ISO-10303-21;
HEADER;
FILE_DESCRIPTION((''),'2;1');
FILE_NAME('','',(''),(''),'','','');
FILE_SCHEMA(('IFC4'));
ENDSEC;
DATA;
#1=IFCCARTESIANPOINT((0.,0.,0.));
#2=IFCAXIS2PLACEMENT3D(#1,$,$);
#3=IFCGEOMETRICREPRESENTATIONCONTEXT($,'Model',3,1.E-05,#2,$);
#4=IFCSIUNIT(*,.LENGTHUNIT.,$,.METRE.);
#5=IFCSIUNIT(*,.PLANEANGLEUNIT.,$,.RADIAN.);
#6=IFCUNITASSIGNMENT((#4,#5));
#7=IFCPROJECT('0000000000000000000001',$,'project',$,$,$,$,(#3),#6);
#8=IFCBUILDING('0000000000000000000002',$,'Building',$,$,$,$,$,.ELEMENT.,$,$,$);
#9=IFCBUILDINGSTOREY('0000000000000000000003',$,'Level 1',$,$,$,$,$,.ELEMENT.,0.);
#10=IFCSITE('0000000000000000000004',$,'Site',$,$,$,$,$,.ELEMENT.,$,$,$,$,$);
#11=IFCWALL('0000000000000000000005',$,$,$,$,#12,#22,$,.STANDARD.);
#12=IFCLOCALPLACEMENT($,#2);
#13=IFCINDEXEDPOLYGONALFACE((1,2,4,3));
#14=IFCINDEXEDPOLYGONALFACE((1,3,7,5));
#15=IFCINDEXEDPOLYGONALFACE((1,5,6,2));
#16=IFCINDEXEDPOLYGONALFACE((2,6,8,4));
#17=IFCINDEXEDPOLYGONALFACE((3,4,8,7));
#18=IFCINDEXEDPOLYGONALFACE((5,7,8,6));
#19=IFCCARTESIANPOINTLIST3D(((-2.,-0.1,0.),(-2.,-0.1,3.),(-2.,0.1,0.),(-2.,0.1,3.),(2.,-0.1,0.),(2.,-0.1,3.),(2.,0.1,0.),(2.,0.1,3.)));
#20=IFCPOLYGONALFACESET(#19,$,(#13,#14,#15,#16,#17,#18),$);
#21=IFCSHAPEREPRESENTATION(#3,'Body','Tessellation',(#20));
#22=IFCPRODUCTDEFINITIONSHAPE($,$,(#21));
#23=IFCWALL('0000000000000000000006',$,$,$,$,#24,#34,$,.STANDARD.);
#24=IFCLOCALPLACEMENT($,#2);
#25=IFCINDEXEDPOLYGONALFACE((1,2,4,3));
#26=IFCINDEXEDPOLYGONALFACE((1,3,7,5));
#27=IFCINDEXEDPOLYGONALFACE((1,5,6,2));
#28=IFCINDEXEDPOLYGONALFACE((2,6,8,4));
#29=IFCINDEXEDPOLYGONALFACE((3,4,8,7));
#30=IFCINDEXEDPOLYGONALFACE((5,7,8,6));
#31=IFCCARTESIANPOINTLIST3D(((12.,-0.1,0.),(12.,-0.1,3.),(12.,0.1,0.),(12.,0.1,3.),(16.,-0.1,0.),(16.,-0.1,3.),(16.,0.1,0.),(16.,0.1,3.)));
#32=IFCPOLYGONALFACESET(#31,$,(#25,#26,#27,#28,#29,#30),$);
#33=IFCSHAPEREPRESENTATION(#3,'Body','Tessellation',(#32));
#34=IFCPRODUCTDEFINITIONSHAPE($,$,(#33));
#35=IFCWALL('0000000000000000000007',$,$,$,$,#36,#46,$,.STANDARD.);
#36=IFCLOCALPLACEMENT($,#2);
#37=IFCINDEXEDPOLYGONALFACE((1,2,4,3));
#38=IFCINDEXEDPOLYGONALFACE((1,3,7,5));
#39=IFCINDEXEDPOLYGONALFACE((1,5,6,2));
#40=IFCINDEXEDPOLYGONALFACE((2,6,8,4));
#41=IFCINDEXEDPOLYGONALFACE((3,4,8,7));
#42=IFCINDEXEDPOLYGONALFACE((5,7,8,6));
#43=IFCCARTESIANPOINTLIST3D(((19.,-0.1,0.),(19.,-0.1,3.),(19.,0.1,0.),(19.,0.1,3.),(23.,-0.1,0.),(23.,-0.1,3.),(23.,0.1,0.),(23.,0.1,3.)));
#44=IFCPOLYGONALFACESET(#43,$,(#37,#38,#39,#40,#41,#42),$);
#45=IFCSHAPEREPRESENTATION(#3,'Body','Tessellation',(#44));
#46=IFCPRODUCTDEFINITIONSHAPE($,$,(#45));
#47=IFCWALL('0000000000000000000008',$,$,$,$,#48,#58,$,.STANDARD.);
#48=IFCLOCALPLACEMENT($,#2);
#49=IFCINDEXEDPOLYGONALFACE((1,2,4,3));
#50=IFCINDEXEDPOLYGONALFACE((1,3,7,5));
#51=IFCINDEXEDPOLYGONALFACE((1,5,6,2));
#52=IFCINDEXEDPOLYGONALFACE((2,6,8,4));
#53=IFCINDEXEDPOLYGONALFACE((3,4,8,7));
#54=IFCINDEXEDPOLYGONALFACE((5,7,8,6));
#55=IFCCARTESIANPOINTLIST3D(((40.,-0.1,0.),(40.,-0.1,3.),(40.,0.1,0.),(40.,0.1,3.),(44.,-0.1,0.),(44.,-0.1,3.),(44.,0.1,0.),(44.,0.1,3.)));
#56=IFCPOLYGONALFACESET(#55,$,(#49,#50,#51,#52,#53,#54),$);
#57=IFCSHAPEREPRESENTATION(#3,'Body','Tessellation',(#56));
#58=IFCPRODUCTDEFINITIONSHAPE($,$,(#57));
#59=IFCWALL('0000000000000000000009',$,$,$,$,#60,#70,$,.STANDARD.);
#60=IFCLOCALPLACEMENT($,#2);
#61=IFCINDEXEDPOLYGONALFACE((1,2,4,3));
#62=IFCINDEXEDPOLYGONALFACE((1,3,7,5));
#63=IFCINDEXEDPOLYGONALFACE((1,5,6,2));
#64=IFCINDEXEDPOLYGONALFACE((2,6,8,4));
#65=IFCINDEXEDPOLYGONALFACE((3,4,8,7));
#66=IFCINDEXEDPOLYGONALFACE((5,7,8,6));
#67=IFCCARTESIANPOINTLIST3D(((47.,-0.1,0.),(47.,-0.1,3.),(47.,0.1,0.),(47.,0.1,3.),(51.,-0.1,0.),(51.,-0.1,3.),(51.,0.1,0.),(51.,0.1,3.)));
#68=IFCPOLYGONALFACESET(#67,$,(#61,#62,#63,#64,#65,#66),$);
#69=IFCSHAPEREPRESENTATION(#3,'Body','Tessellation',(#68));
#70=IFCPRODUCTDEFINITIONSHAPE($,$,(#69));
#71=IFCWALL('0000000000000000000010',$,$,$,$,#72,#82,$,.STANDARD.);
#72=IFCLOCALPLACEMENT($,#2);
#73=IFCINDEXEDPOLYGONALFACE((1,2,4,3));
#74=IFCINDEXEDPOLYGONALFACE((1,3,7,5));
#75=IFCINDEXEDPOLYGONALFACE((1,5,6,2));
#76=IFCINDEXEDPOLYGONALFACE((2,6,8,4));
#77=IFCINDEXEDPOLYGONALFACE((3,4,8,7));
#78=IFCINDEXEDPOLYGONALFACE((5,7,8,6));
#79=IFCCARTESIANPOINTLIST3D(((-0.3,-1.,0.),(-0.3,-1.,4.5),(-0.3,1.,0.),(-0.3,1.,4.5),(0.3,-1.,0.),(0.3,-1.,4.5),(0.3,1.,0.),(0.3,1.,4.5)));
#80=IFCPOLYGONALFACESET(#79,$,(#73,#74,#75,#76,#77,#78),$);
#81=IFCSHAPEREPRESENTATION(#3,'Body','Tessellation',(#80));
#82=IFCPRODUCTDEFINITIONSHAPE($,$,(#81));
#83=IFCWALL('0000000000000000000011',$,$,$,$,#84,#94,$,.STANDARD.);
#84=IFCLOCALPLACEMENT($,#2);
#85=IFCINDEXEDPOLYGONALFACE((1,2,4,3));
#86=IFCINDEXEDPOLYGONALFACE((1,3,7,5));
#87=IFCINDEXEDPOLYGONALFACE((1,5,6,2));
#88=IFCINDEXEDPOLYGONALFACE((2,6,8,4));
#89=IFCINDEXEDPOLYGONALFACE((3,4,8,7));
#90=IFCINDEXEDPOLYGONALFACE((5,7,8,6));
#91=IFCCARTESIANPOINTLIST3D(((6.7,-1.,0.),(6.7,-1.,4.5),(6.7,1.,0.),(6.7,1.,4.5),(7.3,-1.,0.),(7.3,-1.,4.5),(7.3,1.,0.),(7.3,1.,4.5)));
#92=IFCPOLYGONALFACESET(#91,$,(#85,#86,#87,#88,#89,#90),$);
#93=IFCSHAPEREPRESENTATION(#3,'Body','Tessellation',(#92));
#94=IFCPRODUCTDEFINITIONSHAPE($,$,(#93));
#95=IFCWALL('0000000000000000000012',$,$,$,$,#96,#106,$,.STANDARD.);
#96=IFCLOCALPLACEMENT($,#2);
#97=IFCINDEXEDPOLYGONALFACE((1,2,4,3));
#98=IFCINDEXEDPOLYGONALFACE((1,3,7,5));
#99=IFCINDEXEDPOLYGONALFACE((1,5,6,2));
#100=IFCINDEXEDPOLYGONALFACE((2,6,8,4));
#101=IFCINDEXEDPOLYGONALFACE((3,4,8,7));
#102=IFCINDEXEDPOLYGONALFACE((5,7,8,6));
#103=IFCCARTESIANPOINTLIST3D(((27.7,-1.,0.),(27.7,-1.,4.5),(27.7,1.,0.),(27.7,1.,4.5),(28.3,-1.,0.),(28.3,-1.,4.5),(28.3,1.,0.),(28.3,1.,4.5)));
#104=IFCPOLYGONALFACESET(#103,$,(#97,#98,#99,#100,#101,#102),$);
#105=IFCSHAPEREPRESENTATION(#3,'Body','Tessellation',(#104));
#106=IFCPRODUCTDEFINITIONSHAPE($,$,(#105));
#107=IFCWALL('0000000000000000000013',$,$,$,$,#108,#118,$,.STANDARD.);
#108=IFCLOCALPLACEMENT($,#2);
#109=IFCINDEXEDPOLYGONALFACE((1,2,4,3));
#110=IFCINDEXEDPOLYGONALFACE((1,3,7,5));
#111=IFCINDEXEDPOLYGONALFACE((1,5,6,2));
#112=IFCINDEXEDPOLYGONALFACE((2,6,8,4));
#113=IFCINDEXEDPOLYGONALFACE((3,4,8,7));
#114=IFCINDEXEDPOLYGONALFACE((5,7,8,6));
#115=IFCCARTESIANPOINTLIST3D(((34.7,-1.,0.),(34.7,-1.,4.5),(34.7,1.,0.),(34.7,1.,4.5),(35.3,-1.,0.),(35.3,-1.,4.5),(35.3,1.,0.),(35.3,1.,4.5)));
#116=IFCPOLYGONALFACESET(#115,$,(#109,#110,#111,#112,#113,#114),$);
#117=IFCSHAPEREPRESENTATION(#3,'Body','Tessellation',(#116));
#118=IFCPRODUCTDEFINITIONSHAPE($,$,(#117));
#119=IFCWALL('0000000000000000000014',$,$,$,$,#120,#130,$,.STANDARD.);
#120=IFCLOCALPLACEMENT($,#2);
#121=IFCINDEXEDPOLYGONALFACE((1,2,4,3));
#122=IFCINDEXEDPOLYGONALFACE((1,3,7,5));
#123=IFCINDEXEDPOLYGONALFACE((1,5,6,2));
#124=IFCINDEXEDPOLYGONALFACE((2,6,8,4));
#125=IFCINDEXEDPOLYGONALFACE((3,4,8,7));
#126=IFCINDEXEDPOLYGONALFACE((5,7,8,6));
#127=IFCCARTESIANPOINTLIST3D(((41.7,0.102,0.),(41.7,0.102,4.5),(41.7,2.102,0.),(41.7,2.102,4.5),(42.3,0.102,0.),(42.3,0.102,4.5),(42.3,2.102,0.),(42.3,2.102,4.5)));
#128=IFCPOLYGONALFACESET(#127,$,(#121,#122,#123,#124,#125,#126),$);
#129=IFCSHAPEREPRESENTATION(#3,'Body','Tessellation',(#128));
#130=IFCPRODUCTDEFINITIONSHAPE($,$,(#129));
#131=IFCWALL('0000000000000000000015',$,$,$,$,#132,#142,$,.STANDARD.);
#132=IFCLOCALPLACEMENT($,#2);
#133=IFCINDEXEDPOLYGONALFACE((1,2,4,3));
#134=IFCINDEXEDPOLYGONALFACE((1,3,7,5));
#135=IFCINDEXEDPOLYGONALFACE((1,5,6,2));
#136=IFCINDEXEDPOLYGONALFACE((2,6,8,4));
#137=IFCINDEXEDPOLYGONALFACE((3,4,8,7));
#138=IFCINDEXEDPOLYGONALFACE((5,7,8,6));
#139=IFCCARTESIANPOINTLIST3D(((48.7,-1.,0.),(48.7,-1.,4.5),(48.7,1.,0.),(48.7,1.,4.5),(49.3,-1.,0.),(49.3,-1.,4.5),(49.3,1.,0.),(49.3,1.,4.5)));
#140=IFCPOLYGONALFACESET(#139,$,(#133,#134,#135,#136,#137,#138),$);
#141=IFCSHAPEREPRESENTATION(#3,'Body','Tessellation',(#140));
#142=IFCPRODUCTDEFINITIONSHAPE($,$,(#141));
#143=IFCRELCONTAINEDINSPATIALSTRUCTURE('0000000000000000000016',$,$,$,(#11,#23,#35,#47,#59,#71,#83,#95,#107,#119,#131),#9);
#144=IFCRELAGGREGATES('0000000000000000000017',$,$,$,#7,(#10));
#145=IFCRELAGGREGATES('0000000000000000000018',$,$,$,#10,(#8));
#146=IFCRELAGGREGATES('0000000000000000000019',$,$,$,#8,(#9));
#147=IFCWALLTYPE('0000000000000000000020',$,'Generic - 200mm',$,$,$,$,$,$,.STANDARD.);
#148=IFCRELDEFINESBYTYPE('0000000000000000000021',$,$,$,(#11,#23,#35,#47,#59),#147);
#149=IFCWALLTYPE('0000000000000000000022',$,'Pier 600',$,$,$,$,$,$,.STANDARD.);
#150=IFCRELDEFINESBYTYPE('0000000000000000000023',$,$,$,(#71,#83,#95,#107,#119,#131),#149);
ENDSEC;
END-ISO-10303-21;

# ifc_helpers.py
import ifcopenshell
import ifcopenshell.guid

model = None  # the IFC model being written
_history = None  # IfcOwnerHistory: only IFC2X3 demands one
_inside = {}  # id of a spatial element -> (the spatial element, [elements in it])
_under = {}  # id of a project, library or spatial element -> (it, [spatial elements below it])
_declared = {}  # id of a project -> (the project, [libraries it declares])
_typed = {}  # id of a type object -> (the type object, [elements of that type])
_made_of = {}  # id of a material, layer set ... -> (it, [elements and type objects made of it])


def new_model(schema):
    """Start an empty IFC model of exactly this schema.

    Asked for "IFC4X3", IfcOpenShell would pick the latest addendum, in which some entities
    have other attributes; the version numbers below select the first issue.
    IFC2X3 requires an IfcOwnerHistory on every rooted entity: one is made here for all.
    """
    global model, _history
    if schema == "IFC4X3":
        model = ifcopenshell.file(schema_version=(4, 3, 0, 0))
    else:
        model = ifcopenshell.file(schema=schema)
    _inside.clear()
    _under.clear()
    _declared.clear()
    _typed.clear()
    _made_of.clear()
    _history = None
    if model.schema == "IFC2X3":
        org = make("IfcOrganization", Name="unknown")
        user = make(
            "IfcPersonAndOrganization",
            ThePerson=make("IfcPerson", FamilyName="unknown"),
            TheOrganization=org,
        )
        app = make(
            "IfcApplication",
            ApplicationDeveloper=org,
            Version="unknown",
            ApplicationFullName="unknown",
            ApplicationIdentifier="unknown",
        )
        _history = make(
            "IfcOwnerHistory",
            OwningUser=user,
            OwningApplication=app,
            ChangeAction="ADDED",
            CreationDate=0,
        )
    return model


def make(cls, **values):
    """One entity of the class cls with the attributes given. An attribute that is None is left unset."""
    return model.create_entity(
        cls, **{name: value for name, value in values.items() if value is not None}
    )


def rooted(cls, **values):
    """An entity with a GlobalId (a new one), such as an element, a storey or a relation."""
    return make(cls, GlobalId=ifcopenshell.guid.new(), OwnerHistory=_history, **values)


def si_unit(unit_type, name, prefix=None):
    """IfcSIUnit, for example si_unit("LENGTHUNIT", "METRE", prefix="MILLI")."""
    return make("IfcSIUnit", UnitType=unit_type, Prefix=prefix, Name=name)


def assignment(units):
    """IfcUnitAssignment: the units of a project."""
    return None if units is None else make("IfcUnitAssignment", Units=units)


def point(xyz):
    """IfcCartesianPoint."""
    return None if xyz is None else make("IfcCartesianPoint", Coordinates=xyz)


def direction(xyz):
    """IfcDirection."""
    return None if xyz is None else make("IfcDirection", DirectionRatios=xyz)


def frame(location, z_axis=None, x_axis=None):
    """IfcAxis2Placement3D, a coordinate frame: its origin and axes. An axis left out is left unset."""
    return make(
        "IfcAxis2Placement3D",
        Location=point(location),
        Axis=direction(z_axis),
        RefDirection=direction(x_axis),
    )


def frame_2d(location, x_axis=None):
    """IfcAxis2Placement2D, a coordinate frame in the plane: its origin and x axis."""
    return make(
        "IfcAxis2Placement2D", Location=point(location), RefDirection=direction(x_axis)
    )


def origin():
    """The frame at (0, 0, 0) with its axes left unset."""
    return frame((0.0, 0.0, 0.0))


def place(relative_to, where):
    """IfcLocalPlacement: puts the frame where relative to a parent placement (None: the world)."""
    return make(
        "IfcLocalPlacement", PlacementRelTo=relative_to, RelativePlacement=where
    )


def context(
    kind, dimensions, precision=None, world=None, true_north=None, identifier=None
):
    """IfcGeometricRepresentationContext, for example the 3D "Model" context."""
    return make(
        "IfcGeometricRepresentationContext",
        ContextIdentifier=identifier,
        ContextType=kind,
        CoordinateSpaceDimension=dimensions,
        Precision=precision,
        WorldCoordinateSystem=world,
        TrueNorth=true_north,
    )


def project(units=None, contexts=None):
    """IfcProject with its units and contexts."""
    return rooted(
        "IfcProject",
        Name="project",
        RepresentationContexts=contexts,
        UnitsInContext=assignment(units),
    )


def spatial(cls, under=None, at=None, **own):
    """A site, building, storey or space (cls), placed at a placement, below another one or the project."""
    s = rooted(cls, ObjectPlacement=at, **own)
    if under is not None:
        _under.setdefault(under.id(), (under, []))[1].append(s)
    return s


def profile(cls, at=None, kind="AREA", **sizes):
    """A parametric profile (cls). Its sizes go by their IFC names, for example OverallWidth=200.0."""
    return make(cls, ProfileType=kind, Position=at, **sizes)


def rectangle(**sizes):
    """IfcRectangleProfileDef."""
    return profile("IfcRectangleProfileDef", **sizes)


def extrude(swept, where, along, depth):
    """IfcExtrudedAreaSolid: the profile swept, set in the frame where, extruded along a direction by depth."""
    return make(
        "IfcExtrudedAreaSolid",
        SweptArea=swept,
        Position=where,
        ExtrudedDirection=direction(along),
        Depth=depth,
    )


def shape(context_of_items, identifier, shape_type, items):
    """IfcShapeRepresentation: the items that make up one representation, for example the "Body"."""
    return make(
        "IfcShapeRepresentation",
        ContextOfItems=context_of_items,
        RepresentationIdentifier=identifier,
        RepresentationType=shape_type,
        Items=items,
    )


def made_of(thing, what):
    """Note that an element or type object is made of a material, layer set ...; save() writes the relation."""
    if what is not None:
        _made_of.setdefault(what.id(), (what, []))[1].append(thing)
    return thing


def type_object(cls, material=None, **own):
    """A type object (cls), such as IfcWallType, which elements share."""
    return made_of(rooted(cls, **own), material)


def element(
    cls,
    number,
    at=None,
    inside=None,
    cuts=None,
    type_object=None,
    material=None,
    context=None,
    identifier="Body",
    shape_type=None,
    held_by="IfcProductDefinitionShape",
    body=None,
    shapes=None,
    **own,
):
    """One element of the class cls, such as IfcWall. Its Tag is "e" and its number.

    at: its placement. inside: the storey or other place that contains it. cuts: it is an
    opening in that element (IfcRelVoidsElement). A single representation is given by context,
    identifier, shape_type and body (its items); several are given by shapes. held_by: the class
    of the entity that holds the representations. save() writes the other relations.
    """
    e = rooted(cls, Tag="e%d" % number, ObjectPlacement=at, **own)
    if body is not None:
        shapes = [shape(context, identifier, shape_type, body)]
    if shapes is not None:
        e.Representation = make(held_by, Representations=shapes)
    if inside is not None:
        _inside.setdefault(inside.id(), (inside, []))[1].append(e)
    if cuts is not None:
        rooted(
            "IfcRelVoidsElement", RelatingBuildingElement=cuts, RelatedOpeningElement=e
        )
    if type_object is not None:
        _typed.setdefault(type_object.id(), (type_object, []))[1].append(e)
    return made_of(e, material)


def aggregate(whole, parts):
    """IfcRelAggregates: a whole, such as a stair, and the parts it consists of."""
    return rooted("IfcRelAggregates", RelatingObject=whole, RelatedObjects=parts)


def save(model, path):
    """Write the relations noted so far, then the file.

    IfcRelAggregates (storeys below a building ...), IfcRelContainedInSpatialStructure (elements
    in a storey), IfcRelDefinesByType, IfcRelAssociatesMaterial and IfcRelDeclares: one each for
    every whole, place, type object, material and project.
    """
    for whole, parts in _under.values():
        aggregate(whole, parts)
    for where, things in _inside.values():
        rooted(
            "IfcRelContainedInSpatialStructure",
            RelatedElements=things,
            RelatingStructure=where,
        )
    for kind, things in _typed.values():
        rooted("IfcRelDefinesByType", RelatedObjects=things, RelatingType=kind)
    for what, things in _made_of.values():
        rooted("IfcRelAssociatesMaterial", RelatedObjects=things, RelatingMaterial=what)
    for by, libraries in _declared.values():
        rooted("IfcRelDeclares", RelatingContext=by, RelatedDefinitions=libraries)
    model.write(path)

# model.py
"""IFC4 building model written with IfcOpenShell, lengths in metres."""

from ifc_helpers import new_model, si_unit, frame, frame_2d, origin, place, context, project, spatial, rectangle, extrude, type_object, element, save


model = new_model("IFC4")

# Units and contexts
model_context = context("Model", 3, precision=1e-05, world=origin())
ifc_project = project(units=[si_unit("LENGTHUNIT", "METRE"), si_unit("PLANEANGLEUNIT", "RADIAN")], contexts=[model_context])

# Site, building, storey
site = spatial("IfcSite", under=ifc_project, Name="Site", CompositionType="ELEMENT")
building = spatial("IfcBuilding", under=site, Name="Building", CompositionType="ELEMENT")
storey = spatial("IfcBuildingStorey", under=building, Name="Level 1", CompositionType="ELEMENT", Elevation=0.0)

# Walls
wall_type_1 = type_object("IfcWallType", Name="Generic - 200mm", PredefinedType="STANDARD")
for number, where, z_axis, x_axis in (
    (1, (-2.0, 0.0, 0.0), (0.0, 0.0, 1.0), (1.0, 0.0, 0.0)),
    (2, (12.0, 0.0, 0.0), (0.0, 0.0, 1.0), (1.0, 0.0, 0.0)),
    (3, (19.0, 0.0, 0.0), (0.0, 0.0, 1.0), (1.0, 0.0, 0.0)),
    (4, (40.0, 0.0, 0.0), (0.0, 0.0, 1.0), (1.0, 0.0, 0.0)),
    (5, (47.0, 0.0, 0.0), (0.0, 0.0, 1.0), (1.0, 0.0, 0.0)),
):
    element("IfcWall", number, at=place(None, frame(where, z_axis=z_axis, x_axis=x_axis)), inside=storey, type_object=wall_type_1, PredefinedType="STANDARD", context=model_context, shape_type="SweptSolid", body=[
        extrude(rectangle(XDim=4.0, YDim=0.2, at=frame_2d((2.0, 0.0))), origin(), (0.0, 0.0, 1.0), 3.0),
    ])
wall_type_2 = type_object("IfcWallType", Name="Pier 600", PredefinedType="STANDARD")
for number, where, z_axis, x_axis in (
    (6, (0.0, -1.0, 0.0), (0.0, 0.0, 1.0), (0.0, 1.0, 0.0)),
    (7, (7.0, -1.0, 0.0), (0.0, 0.0, 1.0), (0.0, 1.0, 0.0)),
    (8, (28.0, -1.0, 0.0), (0.0, 0.0, 1.0), (0.0, 1.0, 0.0)),
    (9, (35.0, -1.0, 0.0), (0.0, 0.0, 1.0), (0.0, 1.0, 0.0)),
    (10, (42.0, 0.102, 0.0), (0.0, 0.0, 1.0), (0.0, 1.0, 0.0)),
    (11, (49.0, -1.0, 0.0), (0.0, 0.0, 1.0), (0.0, 1.0, 0.0)),
):
    element("IfcWall", number, at=place(None, frame(where, z_axis=z_axis, x_axis=x_axis)), inside=storey, type_object=wall_type_2, PredefinedType="STANDARD", context=model_context, shape_type="SweptSolid", body=[
        extrude(rectangle(XDim=2.0, YDim=0.6, at=frame_2d((1.0, 0.0))), origin(), (0.0, 0.0, 1.0), 4.5),
    ])

save(model, "model.ifc")
